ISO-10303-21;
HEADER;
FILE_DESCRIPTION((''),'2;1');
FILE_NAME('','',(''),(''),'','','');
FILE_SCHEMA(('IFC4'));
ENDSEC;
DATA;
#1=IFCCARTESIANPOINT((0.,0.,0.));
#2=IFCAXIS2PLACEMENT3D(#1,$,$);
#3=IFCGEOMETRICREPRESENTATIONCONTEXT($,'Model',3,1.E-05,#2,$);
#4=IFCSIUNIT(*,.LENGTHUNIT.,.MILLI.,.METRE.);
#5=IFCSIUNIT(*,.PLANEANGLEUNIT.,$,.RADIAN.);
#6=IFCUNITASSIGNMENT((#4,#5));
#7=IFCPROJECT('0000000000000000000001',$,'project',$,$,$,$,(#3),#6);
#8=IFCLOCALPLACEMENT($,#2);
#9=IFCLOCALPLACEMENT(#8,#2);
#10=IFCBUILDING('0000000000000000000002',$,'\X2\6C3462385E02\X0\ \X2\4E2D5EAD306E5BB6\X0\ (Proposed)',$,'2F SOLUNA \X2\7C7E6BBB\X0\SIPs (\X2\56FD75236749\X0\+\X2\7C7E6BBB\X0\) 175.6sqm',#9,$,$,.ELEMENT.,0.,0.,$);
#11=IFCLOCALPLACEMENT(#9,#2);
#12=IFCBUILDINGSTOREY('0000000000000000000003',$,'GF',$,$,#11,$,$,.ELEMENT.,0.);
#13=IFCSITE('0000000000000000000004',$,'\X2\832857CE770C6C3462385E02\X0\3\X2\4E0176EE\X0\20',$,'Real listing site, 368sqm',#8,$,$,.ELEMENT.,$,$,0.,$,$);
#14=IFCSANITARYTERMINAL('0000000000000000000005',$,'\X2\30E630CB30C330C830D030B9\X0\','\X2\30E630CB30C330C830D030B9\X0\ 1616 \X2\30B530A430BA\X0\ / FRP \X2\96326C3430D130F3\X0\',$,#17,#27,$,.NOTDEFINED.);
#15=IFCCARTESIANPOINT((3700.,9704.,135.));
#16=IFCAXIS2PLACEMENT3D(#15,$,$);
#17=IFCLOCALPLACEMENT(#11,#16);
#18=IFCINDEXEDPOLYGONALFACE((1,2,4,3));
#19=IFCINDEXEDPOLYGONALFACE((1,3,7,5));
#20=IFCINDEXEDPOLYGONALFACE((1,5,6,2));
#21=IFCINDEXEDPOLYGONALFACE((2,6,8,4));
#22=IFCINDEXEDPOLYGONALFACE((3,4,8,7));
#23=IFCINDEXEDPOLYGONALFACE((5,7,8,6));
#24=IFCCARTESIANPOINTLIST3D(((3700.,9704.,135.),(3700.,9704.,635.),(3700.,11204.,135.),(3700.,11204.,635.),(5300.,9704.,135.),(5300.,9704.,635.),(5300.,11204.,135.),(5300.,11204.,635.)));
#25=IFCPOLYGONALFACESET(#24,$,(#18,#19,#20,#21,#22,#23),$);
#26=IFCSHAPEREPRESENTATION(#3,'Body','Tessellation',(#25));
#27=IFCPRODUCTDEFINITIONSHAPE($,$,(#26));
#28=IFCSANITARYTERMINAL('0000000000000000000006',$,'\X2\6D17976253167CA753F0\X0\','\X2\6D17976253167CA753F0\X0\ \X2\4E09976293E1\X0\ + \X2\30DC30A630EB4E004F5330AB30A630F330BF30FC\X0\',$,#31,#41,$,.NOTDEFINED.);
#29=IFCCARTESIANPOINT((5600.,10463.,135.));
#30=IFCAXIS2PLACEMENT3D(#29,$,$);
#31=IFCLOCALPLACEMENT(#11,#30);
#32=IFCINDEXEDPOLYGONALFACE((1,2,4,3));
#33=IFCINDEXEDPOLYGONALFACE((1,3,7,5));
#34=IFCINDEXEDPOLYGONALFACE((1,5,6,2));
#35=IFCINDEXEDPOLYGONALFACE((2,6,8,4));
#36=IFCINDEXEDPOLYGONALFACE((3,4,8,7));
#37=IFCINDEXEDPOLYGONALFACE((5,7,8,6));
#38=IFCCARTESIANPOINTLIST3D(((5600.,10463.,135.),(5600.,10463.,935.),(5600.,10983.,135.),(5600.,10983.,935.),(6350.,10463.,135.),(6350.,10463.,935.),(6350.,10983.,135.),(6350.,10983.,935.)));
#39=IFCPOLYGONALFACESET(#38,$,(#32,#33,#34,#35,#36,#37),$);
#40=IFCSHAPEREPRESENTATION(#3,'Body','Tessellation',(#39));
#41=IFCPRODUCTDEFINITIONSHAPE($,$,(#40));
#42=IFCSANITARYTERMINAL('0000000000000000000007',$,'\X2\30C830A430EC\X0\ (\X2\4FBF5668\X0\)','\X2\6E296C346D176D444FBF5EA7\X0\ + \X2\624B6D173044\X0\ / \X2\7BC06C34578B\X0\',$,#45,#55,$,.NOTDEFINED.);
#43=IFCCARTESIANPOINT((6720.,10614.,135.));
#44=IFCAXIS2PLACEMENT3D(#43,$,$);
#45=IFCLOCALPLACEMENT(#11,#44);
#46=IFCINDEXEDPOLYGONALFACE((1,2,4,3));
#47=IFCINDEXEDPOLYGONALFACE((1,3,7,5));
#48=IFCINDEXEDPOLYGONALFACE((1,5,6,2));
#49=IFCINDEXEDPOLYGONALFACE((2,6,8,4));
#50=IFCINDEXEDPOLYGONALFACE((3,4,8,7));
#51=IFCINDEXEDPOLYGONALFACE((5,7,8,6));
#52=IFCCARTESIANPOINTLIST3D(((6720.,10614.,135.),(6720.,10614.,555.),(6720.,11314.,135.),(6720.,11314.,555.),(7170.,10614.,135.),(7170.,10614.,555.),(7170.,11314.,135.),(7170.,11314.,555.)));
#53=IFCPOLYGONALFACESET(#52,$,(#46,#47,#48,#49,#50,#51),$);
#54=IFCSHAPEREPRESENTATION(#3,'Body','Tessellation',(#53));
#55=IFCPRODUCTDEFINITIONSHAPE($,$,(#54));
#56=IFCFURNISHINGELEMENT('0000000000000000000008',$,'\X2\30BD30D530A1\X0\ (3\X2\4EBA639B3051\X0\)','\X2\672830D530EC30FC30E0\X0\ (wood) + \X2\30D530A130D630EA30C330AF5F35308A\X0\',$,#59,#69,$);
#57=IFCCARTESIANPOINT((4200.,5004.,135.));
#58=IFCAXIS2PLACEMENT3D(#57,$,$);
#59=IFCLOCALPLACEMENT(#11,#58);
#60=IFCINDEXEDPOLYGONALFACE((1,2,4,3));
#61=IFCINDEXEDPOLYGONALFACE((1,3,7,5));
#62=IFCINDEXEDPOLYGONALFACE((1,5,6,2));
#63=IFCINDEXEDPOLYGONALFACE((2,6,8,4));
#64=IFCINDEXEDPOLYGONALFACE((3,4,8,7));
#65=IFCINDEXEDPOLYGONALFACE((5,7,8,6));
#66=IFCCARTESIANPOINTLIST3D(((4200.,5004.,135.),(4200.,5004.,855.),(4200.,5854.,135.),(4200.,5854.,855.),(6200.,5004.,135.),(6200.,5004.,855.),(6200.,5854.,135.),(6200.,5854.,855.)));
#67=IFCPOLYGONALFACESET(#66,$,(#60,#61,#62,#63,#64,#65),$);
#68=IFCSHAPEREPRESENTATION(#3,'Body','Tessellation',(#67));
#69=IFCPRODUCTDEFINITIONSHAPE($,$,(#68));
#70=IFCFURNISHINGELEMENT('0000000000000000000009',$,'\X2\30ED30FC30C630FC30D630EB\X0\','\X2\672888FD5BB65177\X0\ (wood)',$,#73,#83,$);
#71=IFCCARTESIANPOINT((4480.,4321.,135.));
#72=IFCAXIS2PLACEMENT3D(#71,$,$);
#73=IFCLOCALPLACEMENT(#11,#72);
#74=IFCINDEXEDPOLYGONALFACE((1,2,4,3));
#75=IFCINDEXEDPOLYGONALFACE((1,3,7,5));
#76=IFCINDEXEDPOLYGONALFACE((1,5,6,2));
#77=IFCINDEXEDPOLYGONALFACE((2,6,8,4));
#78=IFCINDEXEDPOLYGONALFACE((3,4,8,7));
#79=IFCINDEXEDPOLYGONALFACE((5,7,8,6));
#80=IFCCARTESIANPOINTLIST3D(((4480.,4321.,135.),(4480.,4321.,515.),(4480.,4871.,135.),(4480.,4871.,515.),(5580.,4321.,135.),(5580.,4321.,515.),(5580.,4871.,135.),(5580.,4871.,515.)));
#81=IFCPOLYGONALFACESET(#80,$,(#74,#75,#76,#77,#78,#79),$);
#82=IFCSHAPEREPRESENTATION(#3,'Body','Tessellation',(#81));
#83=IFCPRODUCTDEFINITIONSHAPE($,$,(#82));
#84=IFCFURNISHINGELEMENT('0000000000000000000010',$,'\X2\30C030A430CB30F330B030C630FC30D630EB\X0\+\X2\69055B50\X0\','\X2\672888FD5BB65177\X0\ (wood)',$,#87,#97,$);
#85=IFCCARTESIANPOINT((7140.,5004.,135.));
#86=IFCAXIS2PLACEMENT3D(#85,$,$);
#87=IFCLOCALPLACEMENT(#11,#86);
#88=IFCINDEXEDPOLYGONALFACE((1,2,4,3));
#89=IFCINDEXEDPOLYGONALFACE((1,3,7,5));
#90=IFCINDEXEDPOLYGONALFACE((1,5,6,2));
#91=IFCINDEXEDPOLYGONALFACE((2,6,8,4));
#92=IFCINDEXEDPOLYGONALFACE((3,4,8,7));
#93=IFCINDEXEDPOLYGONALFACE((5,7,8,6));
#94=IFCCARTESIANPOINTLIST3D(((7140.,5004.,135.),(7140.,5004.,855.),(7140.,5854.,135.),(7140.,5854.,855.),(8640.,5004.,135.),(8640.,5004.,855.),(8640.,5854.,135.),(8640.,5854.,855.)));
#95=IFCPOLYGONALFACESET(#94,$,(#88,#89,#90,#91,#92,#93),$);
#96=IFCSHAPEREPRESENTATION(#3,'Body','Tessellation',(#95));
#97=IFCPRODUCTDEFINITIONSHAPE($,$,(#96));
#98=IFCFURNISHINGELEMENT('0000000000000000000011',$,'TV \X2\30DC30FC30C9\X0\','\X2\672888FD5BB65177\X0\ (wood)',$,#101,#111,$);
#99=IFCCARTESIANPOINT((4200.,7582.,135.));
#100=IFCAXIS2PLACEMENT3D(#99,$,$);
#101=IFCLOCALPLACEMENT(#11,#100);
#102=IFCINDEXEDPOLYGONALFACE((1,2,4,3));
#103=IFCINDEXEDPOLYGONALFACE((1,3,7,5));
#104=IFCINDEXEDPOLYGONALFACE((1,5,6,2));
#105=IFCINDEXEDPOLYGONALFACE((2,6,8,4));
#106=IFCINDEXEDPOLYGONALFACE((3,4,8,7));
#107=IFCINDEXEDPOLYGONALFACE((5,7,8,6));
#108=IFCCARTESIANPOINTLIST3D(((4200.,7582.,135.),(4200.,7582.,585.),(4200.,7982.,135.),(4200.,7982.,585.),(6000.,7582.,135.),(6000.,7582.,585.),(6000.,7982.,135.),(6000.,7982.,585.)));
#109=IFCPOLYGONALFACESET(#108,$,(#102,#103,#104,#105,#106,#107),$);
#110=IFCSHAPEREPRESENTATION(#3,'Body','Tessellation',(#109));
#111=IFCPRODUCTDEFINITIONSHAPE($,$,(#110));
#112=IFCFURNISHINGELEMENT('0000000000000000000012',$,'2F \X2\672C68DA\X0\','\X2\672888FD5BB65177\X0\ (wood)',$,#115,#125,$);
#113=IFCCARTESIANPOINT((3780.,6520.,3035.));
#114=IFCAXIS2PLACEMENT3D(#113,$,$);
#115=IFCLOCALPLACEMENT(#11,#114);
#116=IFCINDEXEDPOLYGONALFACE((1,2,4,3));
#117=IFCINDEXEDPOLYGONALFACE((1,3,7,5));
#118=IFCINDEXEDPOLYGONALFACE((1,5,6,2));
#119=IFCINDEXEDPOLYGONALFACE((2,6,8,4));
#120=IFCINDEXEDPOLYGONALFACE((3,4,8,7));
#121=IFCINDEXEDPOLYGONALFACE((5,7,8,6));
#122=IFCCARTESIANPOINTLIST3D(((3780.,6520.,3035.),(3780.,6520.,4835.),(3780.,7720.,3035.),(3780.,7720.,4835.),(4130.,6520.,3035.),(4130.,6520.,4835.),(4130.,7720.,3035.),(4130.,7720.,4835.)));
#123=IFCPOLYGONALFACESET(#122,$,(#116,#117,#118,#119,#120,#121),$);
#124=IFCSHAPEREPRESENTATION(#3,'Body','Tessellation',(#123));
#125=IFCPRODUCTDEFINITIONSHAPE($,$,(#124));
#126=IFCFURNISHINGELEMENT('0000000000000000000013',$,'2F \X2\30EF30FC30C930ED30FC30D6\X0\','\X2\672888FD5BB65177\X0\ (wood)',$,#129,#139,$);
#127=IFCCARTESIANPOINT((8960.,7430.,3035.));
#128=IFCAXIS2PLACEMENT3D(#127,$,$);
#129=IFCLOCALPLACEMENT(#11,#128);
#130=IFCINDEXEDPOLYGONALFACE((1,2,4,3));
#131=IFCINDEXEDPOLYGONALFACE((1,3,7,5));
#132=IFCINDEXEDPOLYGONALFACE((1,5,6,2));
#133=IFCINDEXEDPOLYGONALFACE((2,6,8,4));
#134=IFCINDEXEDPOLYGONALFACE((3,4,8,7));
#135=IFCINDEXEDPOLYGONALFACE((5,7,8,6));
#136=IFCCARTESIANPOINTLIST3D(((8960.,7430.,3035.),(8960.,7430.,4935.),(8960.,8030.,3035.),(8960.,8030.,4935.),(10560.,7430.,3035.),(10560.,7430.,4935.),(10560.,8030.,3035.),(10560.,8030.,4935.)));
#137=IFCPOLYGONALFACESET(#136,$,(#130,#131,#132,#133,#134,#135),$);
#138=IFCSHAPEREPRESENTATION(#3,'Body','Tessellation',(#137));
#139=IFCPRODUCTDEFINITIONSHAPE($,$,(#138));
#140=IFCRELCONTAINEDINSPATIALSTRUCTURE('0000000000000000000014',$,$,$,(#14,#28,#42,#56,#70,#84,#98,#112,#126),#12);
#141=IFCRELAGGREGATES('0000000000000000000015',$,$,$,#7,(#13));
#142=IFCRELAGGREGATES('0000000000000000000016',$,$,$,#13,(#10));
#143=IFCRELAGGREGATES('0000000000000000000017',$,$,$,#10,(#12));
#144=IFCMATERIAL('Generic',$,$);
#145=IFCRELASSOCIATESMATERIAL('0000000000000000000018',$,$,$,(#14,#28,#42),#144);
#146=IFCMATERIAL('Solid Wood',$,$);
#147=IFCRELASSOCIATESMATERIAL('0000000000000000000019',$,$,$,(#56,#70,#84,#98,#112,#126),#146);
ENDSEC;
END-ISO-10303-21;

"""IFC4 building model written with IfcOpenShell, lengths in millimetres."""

from ifc_helpers import new_model, si_unit, frame, frame_2d, origin, place, context, project, spatial, rectangle, extrude, material, element, save


model = new_model("IFC4")

# Units and contexts
model_context = context("Model", 3, precision=1e-05, world=origin())
ifc_project = project(units=[si_unit("LENGTHUNIT", "METRE", prefix="MILLI"), si_unit("PLANEANGLEUNIT", "RADIAN")], contexts=[model_context])

# Site, building, storey
site_placement = place(None, origin())
site = spatial("IfcSite", under=ifc_project, at=site_placement, Name="茨城県水戸市3丁目20", ObjectType="Real listing site, 368sqm", CompositionType="ELEMENT", RefElevation=0.0)
building_placement = place(site_placement, origin())
building = spatial("IfcBuilding", under=site, at=building_placement, Name="水戸市 中庭の家 (Proposed)", ObjectType="2F SOLUNA 籾殻SIPs (国産杉+籾殻) 175.6sqm", CompositionType="ELEMENT", ElevationOfRefHeight=0.0, ElevationOfTerrain=0.0)
storey_placement = place(building_placement, origin())
storey = spatial("IfcBuildingStorey", under=building, at=storey_placement, Name="GF", CompositionType="ELEMENT", Elevation=0.0)

# Shared definitions
ifc_material_1 = material(Name="Generic")

# Shared definitions
ifc_material_2 = material(Name="Solid Wood")

# Sanitary terminals
sanitary_terminal_1_placement = place(storey_placement, frame((3700.0, 9704.0, 135.0)))
element("IfcSanitaryTerminal", 1, at=sanitary_terminal_1_placement, inside=storey, material=ifc_material_1, Name="ユニットバス", Description="ユニットバス 1616 サイズ / FRP 防水パン", PredefinedType="NOTDEFINED", context=model_context, shape_type="SweptSolid", body=[
    extrude(rectangle(XDim=1600.0, YDim=1500.0, at=frame_2d((800.0, 750.0))), frame((3700.0, 9704.0, 135.0)), (0.0, 0.0, 1.0), 500.0),
])
sanitary_terminal_2_placement = place(storey_placement, frame((5600.0, 10463.0, 135.0)))
element("IfcSanitaryTerminal", 2, at=sanitary_terminal_2_placement, inside=storey, material=ifc_material_1, Name="洗面化粧台", Description="洗面化粧台 三面鏡 + ボウル一体カウンター", PredefinedType="NOTDEFINED", context=model_context, shape_type="SweptSolid", body=[
    extrude(rectangle(XDim=750.0, YDim=520.0, at=frame_2d((375.0, 260.0))), frame((5600.0, 10463.0, 135.0)), (0.0, 0.0, 1.0), 800.0),
])
sanitary_terminal_3_placement = place(storey_placement, frame((6720.0, 10614.0, 135.0)))
element("IfcSanitaryTerminal", 3, at=sanitary_terminal_3_placement, inside=storey, material=ifc_material_1, Name="トイレ (便器)", Description="温水洗浄便座 + 手洗い / 節水型", PredefinedType="NOTDEFINED", context=model_context, shape_type="SweptSolid", body=[
    extrude(rectangle(XDim=450.0, YDim=700.0, at=frame_2d((225.0, 350.0))), frame((6720.0, 10614.0, 135.0)), (0.0, 0.0, 1.0), 420.0),
])

# Furnishing elements
furnishing_1_placement = place(storey_placement, frame((4200.0, 5004.0, 135.0)))
element("IfcFurnishingElement", 4, at=furnishing_1_placement, inside=storey, material=ifc_material_2, Name="ソファ (3人掛け)", Description="木フレーム (wood) + ファブリック張り", context=model_context, shape_type="SweptSolid", body=[
    extrude(rectangle(XDim=2000.0, YDim=850.0, at=frame_2d((1000.0, 425.0))), frame((4200.0, 5004.0, 135.0)), (0.0, 0.0, 1.0), 720.0),
])
furnishing_2_placement = place(storey_placement, frame((4480.0, 4321.0, 135.0)))
element("IfcFurnishingElement", 5, at=furnishing_2_placement, inside=storey, material=ifc_material_2, Name="ローテーブル", Description="木製家具 (wood)", context=model_context, shape_type="SweptSolid", body=[
    extrude(rectangle(XDim=1100.0, YDim=550.0, at=frame_2d((550.0, 275.0))), frame((4480.0, 4321.0, 135.0)), (0.0, 0.0, 1.0), 380.0),
])
furnishing_3_placement = place(storey_placement, frame((7140.0, 5004.0, 135.0)))
element("IfcFurnishingElement", 6, at=furnishing_3_placement, inside=storey, material=ifc_material_2, Name="ダイニングテーブル+椅子", Description="木製家具 (wood)", context=model_context, shape_type="SweptSolid", body=[
    extrude(rectangle(XDim=1500.0, YDim=850.0, at=frame_2d((750.0, 425.0))), frame((7140.0, 5004.0, 135.0)), (0.0, 0.0, 1.0), 720.0),
])
furnishing_4_placement = place(storey_placement, frame((4200.0, 7582.0, 135.0)))
element("IfcFurnishingElement", 7, at=furnishing_4_placement, inside=storey, material=ifc_material_2, Name="TV ボード", Description="木製家具 (wood)", context=model_context, shape_type="SweptSolid", body=[
    extrude(rectangle(XDim=1800.0, YDim=400.0, at=frame_2d((900.0, 200.0))), frame((4200.0, 7582.0, 135.0)), (0.0, 0.0, 1.0), 450.0),
])
furnishing_5_placement = place(storey_placement, frame((3780.0, 6520.0, 3035.0)))
element("IfcFurnishingElement", 8, at=furnishing_5_placement, inside=storey, material=ifc_material_2, Name="2F 本棚", Description="木製家具 (wood)", context=model_context, shape_type="SweptSolid", body=[
    extrude(rectangle(XDim=350.0, YDim=1200.0, at=frame_2d((175.0, 600.0))), frame((3780.0, 6520.0, 3035.0)), (0.0, 0.0, 1.0), 1800.0),
])
furnishing_6_placement = place(storey_placement, frame((8960.0, 7430.0, 3035.0)))
element("IfcFurnishingElement", 9, at=furnishing_6_placement, inside=storey, material=ifc_material_2, Name="2F ワードローブ", Description="木製家具 (wood)", context=model_context, shape_type="SweptSolid", body=[
    extrude(rectangle(XDim=1600.0, YDim=600.0, at=frame_2d((800.0, 300.0))), frame((8960.0, 7430.0, 3035.0)), (0.0, 0.0, 1.0), 1900.0),
])

save(model, "model.ifc")
